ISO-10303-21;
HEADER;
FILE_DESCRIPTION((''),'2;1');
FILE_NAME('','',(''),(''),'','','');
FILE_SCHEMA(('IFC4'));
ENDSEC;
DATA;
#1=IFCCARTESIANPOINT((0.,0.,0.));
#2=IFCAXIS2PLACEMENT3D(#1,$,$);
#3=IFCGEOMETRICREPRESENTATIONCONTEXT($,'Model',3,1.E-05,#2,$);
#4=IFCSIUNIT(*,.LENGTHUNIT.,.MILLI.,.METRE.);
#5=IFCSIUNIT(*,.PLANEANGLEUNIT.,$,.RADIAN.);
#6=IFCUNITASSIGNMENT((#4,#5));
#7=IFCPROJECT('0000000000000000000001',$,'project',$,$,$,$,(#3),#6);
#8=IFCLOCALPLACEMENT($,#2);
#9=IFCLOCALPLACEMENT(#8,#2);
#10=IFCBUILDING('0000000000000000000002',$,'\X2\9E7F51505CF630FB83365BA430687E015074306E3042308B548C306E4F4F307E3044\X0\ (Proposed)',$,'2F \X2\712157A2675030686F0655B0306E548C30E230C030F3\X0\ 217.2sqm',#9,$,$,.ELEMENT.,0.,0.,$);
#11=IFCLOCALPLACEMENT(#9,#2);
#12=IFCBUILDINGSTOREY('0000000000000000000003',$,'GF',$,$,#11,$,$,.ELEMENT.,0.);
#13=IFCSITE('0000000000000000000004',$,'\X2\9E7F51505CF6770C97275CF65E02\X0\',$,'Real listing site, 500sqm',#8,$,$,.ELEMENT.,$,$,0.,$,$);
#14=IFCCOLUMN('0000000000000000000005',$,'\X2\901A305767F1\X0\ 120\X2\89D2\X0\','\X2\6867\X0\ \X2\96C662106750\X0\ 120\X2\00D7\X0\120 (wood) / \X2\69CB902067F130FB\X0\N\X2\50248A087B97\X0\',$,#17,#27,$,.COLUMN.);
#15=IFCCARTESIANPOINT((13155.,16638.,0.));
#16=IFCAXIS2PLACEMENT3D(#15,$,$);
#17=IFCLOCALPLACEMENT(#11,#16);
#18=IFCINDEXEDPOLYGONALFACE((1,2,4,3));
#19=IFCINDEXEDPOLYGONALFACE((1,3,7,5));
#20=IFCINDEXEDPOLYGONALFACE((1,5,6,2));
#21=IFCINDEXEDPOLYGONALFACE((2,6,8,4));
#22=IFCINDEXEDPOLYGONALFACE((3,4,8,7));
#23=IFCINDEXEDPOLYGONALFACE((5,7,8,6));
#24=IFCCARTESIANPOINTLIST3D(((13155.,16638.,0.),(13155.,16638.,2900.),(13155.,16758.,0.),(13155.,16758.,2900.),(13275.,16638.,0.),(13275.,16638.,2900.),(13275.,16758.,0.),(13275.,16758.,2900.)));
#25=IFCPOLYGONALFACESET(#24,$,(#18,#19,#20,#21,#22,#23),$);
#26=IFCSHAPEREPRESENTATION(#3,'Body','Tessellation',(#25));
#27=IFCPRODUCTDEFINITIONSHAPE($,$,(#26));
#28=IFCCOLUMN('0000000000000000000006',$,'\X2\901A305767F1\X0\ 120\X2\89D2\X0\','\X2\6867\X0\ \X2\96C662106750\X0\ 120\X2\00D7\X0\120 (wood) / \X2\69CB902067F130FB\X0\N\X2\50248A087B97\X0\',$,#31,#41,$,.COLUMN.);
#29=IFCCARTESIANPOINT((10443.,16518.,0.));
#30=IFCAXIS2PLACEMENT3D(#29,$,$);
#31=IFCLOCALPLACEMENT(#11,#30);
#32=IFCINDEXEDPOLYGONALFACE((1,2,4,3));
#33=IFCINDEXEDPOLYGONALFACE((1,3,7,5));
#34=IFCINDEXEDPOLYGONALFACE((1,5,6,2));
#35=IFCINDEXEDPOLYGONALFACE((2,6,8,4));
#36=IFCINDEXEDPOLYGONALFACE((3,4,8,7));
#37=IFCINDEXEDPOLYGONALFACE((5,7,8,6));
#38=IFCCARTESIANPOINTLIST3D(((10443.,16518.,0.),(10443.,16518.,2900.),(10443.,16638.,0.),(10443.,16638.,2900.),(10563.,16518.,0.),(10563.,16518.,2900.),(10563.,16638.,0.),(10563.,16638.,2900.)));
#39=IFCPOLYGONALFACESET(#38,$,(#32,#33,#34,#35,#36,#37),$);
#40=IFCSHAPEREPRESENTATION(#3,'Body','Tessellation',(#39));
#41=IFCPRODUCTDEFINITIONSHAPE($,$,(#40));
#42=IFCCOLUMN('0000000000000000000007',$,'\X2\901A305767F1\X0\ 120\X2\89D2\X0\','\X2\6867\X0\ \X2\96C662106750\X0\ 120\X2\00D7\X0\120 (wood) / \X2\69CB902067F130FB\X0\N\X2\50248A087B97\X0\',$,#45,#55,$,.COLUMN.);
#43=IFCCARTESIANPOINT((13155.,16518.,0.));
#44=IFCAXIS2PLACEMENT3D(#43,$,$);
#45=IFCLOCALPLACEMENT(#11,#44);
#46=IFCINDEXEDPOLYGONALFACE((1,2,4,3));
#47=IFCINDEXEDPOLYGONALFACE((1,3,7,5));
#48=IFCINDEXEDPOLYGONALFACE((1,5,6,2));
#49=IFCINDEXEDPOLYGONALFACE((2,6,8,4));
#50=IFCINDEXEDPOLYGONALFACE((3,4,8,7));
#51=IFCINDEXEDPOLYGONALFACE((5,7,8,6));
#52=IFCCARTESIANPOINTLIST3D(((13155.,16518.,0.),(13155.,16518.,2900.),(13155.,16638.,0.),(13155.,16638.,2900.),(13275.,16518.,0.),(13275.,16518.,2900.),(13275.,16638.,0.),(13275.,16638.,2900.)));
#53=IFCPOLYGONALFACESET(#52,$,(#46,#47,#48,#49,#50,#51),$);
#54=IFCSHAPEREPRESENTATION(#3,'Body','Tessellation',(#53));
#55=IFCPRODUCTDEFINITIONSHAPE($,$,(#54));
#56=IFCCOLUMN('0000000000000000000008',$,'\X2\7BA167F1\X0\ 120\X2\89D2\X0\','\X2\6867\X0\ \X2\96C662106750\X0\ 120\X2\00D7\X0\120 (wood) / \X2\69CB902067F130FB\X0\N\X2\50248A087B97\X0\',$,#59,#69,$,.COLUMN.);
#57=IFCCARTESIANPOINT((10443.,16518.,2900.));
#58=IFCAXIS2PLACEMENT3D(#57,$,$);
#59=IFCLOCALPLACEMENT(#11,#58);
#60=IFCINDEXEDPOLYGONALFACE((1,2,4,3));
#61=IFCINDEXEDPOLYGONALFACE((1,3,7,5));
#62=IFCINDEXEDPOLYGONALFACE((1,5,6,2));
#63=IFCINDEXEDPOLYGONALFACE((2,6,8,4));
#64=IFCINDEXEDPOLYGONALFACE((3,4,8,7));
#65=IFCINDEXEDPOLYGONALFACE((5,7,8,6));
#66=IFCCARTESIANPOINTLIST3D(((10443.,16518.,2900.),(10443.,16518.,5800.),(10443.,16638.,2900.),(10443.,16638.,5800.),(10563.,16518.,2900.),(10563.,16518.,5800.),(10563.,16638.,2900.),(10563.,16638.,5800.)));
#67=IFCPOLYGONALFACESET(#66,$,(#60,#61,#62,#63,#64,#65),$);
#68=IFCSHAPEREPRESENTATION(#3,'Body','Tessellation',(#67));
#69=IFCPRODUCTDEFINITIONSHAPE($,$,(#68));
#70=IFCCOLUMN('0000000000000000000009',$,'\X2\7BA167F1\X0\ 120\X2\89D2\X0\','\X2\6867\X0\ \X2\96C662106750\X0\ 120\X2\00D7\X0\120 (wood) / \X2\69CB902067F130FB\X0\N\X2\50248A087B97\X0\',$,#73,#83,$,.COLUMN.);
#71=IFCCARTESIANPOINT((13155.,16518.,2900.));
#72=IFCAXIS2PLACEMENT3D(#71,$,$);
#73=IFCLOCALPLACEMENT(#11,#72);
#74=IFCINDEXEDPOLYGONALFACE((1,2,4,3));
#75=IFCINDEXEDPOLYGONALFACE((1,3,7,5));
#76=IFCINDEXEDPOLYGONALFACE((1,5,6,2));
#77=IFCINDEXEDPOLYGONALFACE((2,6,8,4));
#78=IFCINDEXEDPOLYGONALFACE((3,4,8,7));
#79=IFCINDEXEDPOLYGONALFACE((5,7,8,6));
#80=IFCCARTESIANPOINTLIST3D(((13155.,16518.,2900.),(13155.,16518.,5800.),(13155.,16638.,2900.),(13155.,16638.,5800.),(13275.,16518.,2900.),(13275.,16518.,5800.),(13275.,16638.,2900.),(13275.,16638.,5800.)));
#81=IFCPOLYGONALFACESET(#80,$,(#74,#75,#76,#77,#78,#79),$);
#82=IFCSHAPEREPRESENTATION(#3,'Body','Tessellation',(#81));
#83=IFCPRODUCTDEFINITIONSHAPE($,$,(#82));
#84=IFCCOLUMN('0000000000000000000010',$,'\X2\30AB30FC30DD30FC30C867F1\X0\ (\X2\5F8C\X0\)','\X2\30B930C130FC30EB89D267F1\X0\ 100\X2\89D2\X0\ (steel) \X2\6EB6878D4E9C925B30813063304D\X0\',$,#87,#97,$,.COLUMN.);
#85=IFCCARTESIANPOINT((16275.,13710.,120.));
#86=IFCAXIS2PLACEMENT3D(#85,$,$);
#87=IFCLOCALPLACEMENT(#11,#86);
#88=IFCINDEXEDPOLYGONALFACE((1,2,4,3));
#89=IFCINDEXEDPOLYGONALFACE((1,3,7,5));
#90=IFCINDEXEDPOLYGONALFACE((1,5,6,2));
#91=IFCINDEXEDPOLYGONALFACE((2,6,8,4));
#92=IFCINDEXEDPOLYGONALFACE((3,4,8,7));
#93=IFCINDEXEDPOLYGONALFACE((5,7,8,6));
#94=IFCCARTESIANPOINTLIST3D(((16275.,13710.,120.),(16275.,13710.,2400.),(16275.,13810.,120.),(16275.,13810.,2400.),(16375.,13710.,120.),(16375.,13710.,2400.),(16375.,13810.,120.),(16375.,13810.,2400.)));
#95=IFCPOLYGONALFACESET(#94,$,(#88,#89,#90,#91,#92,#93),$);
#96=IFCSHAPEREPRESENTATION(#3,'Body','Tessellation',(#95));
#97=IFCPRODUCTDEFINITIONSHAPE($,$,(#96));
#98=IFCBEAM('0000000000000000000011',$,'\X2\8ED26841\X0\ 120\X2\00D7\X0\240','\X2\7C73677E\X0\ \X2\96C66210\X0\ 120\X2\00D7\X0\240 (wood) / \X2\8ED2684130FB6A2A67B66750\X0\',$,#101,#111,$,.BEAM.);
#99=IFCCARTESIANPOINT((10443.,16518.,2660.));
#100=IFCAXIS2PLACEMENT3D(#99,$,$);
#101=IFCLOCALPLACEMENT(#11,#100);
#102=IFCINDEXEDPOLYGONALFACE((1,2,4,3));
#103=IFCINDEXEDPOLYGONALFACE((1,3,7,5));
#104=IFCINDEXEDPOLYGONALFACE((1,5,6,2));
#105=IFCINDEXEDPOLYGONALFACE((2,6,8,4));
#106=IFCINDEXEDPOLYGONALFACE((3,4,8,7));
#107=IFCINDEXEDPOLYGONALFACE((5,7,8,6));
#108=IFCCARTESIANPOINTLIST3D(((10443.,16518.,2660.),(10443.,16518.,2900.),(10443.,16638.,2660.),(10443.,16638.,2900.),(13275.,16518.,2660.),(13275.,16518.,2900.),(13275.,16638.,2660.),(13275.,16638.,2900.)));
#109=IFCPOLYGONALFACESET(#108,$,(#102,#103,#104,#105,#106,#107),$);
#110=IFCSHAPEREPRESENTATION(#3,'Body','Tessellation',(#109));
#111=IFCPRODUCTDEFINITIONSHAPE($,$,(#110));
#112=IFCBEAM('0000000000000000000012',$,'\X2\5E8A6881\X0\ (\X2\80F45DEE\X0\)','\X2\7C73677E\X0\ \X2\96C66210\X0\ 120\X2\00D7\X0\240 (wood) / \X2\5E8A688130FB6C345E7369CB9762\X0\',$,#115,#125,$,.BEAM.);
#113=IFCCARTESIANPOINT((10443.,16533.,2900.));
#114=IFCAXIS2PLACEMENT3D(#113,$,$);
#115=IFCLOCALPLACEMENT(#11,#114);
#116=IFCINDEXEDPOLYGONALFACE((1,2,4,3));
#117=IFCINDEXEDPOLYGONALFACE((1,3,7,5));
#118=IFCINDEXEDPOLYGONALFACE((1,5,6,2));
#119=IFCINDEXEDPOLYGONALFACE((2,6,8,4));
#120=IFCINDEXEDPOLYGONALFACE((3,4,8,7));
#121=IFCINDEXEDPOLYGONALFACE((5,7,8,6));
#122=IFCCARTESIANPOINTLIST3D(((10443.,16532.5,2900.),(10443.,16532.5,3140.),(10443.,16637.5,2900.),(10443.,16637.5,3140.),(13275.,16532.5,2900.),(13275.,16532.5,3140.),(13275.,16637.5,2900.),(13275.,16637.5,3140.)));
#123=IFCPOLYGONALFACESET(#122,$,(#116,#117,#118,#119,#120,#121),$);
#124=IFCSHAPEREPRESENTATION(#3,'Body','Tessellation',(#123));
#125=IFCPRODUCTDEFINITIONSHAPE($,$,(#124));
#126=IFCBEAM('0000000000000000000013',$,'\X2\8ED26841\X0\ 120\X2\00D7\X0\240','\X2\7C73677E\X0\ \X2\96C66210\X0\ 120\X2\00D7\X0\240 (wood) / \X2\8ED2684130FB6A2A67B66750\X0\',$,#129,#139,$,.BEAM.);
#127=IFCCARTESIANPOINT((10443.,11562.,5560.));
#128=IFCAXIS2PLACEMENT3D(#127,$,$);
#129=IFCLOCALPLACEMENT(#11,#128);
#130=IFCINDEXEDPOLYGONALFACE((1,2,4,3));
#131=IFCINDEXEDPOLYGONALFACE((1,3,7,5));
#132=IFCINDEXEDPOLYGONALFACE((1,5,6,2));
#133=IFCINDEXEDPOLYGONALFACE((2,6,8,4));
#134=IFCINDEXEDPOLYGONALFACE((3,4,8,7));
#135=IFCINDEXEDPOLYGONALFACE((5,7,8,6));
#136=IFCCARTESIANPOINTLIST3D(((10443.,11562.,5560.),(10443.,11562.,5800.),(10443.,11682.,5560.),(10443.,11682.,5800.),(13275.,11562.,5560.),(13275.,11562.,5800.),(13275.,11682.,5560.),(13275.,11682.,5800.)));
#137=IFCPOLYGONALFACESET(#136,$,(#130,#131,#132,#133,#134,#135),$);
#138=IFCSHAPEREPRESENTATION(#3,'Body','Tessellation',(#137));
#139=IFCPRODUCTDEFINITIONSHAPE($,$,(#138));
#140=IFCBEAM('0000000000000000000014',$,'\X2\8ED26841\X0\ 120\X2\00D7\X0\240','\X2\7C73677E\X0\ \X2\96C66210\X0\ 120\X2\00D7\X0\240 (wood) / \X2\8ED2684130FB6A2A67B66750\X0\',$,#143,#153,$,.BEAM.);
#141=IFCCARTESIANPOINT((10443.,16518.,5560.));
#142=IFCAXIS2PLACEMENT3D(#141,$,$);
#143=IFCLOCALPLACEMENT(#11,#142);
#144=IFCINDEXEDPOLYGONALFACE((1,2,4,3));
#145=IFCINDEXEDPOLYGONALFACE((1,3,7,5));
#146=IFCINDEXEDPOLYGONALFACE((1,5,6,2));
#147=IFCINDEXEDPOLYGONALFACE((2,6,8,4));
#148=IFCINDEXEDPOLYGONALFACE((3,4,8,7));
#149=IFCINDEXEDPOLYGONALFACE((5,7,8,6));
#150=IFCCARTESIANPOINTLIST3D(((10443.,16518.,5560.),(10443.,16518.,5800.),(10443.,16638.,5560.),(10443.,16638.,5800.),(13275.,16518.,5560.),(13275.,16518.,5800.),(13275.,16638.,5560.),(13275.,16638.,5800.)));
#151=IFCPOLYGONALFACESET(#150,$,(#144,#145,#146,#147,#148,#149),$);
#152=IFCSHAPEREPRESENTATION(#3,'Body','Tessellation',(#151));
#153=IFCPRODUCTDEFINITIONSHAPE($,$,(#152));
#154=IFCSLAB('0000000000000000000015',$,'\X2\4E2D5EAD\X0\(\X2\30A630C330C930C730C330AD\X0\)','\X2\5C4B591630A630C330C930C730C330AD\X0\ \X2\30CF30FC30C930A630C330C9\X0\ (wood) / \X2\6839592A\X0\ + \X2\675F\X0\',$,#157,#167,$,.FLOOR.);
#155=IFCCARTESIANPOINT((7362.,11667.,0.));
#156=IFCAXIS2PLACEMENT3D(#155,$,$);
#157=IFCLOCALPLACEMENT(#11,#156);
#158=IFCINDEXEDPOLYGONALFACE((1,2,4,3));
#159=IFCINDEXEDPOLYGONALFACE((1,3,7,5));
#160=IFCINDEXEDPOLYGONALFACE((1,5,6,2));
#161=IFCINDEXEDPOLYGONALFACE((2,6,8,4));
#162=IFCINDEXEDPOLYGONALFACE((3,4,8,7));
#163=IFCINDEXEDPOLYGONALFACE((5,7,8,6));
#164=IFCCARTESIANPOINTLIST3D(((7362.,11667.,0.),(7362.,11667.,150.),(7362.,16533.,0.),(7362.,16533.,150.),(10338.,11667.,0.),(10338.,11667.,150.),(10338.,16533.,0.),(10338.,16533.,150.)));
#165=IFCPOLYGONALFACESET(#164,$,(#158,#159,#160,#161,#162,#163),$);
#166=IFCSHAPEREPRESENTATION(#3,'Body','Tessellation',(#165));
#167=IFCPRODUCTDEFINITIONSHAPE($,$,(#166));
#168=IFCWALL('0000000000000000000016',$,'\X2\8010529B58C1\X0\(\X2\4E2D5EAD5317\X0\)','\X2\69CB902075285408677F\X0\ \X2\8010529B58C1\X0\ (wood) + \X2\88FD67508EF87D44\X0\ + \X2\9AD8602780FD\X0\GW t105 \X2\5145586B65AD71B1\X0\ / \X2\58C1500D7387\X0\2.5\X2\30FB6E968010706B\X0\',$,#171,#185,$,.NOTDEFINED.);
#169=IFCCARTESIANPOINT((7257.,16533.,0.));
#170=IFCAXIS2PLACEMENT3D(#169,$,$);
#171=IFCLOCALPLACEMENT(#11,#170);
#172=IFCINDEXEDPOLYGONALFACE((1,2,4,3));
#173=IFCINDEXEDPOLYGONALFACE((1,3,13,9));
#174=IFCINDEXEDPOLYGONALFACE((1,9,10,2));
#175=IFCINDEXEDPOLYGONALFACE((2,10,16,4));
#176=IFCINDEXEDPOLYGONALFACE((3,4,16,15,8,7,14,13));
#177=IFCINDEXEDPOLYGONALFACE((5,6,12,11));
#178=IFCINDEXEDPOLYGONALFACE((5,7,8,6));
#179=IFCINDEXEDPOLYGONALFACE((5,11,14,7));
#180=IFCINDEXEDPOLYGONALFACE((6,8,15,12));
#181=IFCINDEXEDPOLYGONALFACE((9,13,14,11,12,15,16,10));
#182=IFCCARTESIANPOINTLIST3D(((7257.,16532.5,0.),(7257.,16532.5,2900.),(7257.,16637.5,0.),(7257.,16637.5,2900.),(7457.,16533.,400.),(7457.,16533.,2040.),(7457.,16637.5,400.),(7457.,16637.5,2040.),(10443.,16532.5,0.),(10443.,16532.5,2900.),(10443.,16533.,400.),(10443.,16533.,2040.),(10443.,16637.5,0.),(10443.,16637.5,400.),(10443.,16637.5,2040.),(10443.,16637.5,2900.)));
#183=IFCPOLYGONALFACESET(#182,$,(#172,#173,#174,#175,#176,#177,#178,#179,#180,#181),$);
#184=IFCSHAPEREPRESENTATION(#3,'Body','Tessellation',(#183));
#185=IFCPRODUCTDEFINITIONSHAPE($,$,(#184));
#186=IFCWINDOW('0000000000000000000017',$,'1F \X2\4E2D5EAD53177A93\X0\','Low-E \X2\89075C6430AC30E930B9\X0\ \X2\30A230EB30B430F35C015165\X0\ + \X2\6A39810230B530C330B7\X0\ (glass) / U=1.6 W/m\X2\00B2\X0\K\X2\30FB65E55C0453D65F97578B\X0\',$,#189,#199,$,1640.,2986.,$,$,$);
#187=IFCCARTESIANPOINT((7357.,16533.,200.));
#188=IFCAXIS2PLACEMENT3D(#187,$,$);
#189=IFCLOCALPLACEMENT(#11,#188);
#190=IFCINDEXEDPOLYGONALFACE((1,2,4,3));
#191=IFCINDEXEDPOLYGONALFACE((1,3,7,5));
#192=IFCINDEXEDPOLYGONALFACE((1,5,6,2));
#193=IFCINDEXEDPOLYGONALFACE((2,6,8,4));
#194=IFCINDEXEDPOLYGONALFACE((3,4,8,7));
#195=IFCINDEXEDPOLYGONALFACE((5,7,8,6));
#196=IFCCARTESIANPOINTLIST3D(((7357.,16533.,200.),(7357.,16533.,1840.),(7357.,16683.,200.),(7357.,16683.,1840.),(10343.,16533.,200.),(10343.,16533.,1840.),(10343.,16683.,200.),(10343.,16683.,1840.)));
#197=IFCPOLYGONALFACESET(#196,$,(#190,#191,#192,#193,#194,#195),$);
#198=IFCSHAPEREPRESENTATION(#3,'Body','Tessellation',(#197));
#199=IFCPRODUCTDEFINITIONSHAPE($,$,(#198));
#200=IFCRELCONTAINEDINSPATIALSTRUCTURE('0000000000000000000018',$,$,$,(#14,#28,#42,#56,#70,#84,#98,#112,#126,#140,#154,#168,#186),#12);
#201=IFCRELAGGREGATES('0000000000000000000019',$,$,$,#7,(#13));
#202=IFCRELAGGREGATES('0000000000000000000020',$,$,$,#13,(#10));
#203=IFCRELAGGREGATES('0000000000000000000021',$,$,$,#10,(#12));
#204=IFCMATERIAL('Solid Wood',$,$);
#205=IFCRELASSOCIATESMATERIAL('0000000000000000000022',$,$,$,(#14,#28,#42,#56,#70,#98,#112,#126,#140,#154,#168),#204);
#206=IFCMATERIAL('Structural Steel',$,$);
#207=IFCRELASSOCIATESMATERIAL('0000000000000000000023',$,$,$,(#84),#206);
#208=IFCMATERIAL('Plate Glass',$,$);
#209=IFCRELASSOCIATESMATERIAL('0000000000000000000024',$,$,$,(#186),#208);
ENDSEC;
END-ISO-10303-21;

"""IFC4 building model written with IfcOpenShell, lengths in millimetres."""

from ifc_helpers import new_model, si_unit, frame, frame_2d, origin, place, context, project, spatial, rectangle, extrude, material, element, fill, save


model = new_model("IFC4")

# Units and contexts
model_context = context("Model", 3, precision=1e-05, world=origin())
ifc_project = project(units=[si_unit("LENGTHUNIT", "METRE", prefix="MILLI"), si_unit("PLANEANGLEUNIT", "RADIAN")], contexts=[model_context])

# Site, building, storey
site_placement = place(None, origin())
site = spatial("IfcSite", under=ifc_project, at=site_placement, Name="鹿児島県霧島市", ObjectType="Real listing site, 500sqm", CompositionType="ELEMENT", RefElevation=0.0)
building_placement = place(site_placement, origin())
building = spatial("IfcBuilding", under=site, at=building_placement, Name="鹿児島・茶室と縁側のある和の住まい (Proposed)", ObjectType="2F 無垢材と漆喰の和モダン 217.2sqm", CompositionType="ELEMENT", ElevationOfRefHeight=0.0, ElevationOfTerrain=0.0)
storey_placement = place(building_placement, origin())
storey = spatial("IfcBuildingStorey", under=building, at=storey_placement, Name="GF", CompositionType="ELEMENT", Elevation=0.0)

# Columns
ifc_material_1 = material(Name="Solid Wood")
column_1_placement = place(storey_placement, frame((13155.0, 16638.0, 0.0)))
element("IfcColumn", 1, at=column_1_placement, inside=storey, material=ifc_material_1, Name="通し柱 120角", Description="桧 集成材 120×120 (wood) / 構造柱・N値計算", PredefinedType="COLUMN", context=model_context, shape_type="SweptSolid", body=[
    extrude(rectangle(XDim=120.0, YDim=120.0, at=frame_2d((60.0, 60.0))), frame((13155.0, 16638.0, 0.0)), (0.0, 0.0, 1.0), 2900.0),
])
column_2_placement = place(storey_placement, frame((10443.0, 16518.0, 0.0)))
element("IfcColumn", 2, at=column_2_placement, inside=storey, material=ifc_material_1, Name="通し柱 120角", Description="桧 集成材 120×120 (wood) / 構造柱・N値計算", PredefinedType="COLUMN", context=model_context, shape_type="SweptSolid", body=[
    extrude(rectangle(XDim=120.0, YDim=120.0, at=frame_2d((60.0, 60.0))), frame((10443.0, 16518.0, 0.0)), (0.0, 0.0, 1.0), 2900.0),
])
column_3_placement = place(storey_placement, frame((13155.0, 16518.0, 0.0)))
element("IfcColumn", 3, at=column_3_placement, inside=storey, material=ifc_material_1, Name="通し柱 120角", Description="桧 集成材 120×120 (wood) / 構造柱・N値計算", PredefinedType="COLUMN", context=model_context, shape_type="SweptSolid", body=[
    extrude(rectangle(XDim=120.0, YDim=120.0, at=frame_2d((60.0, 60.0))), frame((13155.0, 16518.0, 0.0)), (0.0, 0.0, 1.0), 2900.0),
])
column_4_placement = place(storey_placement, frame((10443.0, 16518.0, 2900.0)))
element("IfcColumn", 4, at=column_4_placement, inside=storey, material=ifc_material_1, Name="管柱 120角", Description="桧 集成材 120×120 (wood) / 構造柱・N値計算", PredefinedType="COLUMN", context=model_context, shape_type="SweptSolid", body=[
    extrude(rectangle(XDim=120.0, YDim=120.0, at=frame_2d((60.0, 60.0))), frame((10443.0, 16518.0, 2900.0)), (0.0, 0.0, 1.0), 2900.0),
])
column_5_placement = place(storey_placement, frame((13155.0, 16518.0, 2900.0)))
element("IfcColumn", 5, at=column_5_placement, inside=storey, material=ifc_material_1, Name="管柱 120角", Description="桧 集成材 120×120 (wood) / 構造柱・N値計算", PredefinedType="COLUMN", context=model_context, shape_type="SweptSolid", body=[
    extrude(rectangle(XDim=120.0, YDim=120.0, at=frame_2d((60.0, 60.0))), frame((13155.0, 16518.0, 2900.0)), (0.0, 0.0, 1.0), 2900.0),
])
ifc_material_2 = material(Name="Structural Steel")
column_6_placement = place(storey_placement, frame((16275.0, 13710.0, 120.0)))
element("IfcColumn", 6, at=column_6_placement, inside=storey, material=ifc_material_2, Name="カーポート柱 (後)", Description="スチール角柱 100角 (steel) 溶融亜鉛めっき", PredefinedType="COLUMN", context=model_context, shape_type="SweptSolid", body=[
    extrude(rectangle(XDim=100.0, YDim=100.0, at=frame_2d((50.0, 50.0))), frame((16275.0, 13710.0, 120.0)), (0.0, 0.0, 1.0), 2280.0),
])

# Beams
beam_1_placement = place(storey_placement, frame((10443.0, 16518.0, 2660.0)))
element("IfcBeam", 7, at=beam_1_placement, inside=storey, material=ifc_material_1, Name="軒桁 120×240", Description="米松 集成 120×240 (wood) / 軒桁・横架材", PredefinedType="BEAM", context=model_context, shape_type="SweptSolid", body=[
    extrude(rectangle(XDim=2832.0, YDim=120.0, at=frame_2d((1416.0, 60.0))), frame((10443.0, 16518.0, 2660.0)), (0.0, 0.0, 1.0), 240.0),
])
beam_2_placement = place(storey_placement, frame((10443.0, 16533.0, 2900.0)))
element("IfcBeam", 8, at=beam_2_placement, inside=storey, material=ifc_material_1, Name="床梁 (胴差)", Description="米松 集成 120×240 (wood) / 床梁・水平構面", PredefinedType="BEAM", context=model_context, shape_type="SweptSolid", body=[
    extrude(rectangle(XDim=2832.0, YDim=105.0, at=frame_2d((1416.0, 52.0))), frame((10443.0, 16533.0, 2900.0)), (0.0, 0.0, 1.0), 240.0),
])
beam_3_placement = place(storey_placement, frame((10443.0, 11562.0, 5560.0)))
element("IfcBeam", 9, at=beam_3_placement, inside=storey, material=ifc_material_1, Name="軒桁 120×240", Description="米松 集成 120×240 (wood) / 軒桁・横架材", PredefinedType="BEAM", context=model_context, shape_type="SweptSolid", body=[
    extrude(rectangle(XDim=2832.0, YDim=120.0, at=frame_2d((1416.0, 60.0))), frame((10443.0, 11562.0, 5560.0)), (0.0, 0.0, 1.0), 240.0),
])
beam_4_placement = place(storey_placement, frame((10443.0, 16518.0, 5560.0)))
element("IfcBeam", 10, at=beam_4_placement, inside=storey, material=ifc_material_1, Name="軒桁 120×240", Description="米松 集成 120×240 (wood) / 軒桁・横架材", PredefinedType="BEAM", context=model_context, shape_type="SweptSolid", body=[
    extrude(rectangle(XDim=2832.0, YDim=120.0, at=frame_2d((1416.0, 60.0))), frame((10443.0, 16518.0, 5560.0)), (0.0, 0.0, 1.0), 240.0),
])

# Slab
slab_placement = place(storey_placement, frame((7362.0, 11667.0, 0.0)))
element("IfcSlab", 11, at=slab_placement, inside=storey, material=ifc_material_1, Name="中庭(ウッドデッキ)", Description="屋外ウッドデッキ ハードウッド (wood) / 根太 + 束", PredefinedType="FLOOR", context=model_context, shape_type="SweptSolid", body=[
    extrude(rectangle(XDim=2976.0, YDim=4866.0, at=frame_2d((1488.0, 2433.0))), frame((7362.0, 11667.0, 0.0)), (0.0, 0.0, 1.0), 150.0),
])

# Wall, opening, window
wall_1_placement = place(storey_placement, frame((7257.0, 16533.0, 0.0)))
wall_1 = element("IfcWall", 12, at=wall_1_placement, inside=storey, material=ifc_material_1, Name="耐力壁(中庭北)", Description="構造用合板 耐力壁 (wood) + 製材軸組 + 高性能GW t105 充填断熱 / 壁倍率2.5・準耐火", PredefinedType="NOTDEFINED", context=model_context, shape_type="SweptSolid", body=[
    extrude(rectangle(XDim=3186.0, YDim=105.0, at=frame_2d((1593.0, 52.0))), frame((7257.0, 16533.0, 0.0)), (0.0, 0.0, 1.0), 2900.0),
])
opening_1_placement = place(storey_placement, frame((7357.0, 16533.0, 200.0)))
opening_1 = element("IfcOpeningElement", 13, at=opening_1_placement, cuts=wall_1, PredefinedType="NOTDEFINED", context=model_context, shape_type="SweptSolid", body=[
    extrude(rectangle(XDim=2986.0, YDim=150.0, at=frame_2d((1493.0, 75.0))), frame((7357.0, 16533.0, 200.0)), (0.0, 0.0, 1.0), 1640.0),
])
ifc_material_3 = material(Name="Plate Glass")
window_1_placement = place(storey_placement, frame((7357.0, 16533.0, 200.0)))
window_1 = element("IfcWindow", 14, at=window_1_placement, inside=storey, material=ifc_material_3, Name="1F 中庭北窓", Description="Low-E 複層ガラス アルゴン封入 + 樹脂サッシ (glass) / U=1.6 W/m²K・日射取得型", OverallHeight=1640.0, OverallWidth=2986.0, context=model_context, shape_type="SweptSolid", body=[
    extrude(rectangle(XDim=2986.0, YDim=150.0, at=frame_2d((1493.0, 75.0))), frame((7357.0, 16533.0, 200.0)), (0.0, 0.0, 1.0), 1640.0),
])
fill(opening_1, window_1)

save(model, "model.ifc")
